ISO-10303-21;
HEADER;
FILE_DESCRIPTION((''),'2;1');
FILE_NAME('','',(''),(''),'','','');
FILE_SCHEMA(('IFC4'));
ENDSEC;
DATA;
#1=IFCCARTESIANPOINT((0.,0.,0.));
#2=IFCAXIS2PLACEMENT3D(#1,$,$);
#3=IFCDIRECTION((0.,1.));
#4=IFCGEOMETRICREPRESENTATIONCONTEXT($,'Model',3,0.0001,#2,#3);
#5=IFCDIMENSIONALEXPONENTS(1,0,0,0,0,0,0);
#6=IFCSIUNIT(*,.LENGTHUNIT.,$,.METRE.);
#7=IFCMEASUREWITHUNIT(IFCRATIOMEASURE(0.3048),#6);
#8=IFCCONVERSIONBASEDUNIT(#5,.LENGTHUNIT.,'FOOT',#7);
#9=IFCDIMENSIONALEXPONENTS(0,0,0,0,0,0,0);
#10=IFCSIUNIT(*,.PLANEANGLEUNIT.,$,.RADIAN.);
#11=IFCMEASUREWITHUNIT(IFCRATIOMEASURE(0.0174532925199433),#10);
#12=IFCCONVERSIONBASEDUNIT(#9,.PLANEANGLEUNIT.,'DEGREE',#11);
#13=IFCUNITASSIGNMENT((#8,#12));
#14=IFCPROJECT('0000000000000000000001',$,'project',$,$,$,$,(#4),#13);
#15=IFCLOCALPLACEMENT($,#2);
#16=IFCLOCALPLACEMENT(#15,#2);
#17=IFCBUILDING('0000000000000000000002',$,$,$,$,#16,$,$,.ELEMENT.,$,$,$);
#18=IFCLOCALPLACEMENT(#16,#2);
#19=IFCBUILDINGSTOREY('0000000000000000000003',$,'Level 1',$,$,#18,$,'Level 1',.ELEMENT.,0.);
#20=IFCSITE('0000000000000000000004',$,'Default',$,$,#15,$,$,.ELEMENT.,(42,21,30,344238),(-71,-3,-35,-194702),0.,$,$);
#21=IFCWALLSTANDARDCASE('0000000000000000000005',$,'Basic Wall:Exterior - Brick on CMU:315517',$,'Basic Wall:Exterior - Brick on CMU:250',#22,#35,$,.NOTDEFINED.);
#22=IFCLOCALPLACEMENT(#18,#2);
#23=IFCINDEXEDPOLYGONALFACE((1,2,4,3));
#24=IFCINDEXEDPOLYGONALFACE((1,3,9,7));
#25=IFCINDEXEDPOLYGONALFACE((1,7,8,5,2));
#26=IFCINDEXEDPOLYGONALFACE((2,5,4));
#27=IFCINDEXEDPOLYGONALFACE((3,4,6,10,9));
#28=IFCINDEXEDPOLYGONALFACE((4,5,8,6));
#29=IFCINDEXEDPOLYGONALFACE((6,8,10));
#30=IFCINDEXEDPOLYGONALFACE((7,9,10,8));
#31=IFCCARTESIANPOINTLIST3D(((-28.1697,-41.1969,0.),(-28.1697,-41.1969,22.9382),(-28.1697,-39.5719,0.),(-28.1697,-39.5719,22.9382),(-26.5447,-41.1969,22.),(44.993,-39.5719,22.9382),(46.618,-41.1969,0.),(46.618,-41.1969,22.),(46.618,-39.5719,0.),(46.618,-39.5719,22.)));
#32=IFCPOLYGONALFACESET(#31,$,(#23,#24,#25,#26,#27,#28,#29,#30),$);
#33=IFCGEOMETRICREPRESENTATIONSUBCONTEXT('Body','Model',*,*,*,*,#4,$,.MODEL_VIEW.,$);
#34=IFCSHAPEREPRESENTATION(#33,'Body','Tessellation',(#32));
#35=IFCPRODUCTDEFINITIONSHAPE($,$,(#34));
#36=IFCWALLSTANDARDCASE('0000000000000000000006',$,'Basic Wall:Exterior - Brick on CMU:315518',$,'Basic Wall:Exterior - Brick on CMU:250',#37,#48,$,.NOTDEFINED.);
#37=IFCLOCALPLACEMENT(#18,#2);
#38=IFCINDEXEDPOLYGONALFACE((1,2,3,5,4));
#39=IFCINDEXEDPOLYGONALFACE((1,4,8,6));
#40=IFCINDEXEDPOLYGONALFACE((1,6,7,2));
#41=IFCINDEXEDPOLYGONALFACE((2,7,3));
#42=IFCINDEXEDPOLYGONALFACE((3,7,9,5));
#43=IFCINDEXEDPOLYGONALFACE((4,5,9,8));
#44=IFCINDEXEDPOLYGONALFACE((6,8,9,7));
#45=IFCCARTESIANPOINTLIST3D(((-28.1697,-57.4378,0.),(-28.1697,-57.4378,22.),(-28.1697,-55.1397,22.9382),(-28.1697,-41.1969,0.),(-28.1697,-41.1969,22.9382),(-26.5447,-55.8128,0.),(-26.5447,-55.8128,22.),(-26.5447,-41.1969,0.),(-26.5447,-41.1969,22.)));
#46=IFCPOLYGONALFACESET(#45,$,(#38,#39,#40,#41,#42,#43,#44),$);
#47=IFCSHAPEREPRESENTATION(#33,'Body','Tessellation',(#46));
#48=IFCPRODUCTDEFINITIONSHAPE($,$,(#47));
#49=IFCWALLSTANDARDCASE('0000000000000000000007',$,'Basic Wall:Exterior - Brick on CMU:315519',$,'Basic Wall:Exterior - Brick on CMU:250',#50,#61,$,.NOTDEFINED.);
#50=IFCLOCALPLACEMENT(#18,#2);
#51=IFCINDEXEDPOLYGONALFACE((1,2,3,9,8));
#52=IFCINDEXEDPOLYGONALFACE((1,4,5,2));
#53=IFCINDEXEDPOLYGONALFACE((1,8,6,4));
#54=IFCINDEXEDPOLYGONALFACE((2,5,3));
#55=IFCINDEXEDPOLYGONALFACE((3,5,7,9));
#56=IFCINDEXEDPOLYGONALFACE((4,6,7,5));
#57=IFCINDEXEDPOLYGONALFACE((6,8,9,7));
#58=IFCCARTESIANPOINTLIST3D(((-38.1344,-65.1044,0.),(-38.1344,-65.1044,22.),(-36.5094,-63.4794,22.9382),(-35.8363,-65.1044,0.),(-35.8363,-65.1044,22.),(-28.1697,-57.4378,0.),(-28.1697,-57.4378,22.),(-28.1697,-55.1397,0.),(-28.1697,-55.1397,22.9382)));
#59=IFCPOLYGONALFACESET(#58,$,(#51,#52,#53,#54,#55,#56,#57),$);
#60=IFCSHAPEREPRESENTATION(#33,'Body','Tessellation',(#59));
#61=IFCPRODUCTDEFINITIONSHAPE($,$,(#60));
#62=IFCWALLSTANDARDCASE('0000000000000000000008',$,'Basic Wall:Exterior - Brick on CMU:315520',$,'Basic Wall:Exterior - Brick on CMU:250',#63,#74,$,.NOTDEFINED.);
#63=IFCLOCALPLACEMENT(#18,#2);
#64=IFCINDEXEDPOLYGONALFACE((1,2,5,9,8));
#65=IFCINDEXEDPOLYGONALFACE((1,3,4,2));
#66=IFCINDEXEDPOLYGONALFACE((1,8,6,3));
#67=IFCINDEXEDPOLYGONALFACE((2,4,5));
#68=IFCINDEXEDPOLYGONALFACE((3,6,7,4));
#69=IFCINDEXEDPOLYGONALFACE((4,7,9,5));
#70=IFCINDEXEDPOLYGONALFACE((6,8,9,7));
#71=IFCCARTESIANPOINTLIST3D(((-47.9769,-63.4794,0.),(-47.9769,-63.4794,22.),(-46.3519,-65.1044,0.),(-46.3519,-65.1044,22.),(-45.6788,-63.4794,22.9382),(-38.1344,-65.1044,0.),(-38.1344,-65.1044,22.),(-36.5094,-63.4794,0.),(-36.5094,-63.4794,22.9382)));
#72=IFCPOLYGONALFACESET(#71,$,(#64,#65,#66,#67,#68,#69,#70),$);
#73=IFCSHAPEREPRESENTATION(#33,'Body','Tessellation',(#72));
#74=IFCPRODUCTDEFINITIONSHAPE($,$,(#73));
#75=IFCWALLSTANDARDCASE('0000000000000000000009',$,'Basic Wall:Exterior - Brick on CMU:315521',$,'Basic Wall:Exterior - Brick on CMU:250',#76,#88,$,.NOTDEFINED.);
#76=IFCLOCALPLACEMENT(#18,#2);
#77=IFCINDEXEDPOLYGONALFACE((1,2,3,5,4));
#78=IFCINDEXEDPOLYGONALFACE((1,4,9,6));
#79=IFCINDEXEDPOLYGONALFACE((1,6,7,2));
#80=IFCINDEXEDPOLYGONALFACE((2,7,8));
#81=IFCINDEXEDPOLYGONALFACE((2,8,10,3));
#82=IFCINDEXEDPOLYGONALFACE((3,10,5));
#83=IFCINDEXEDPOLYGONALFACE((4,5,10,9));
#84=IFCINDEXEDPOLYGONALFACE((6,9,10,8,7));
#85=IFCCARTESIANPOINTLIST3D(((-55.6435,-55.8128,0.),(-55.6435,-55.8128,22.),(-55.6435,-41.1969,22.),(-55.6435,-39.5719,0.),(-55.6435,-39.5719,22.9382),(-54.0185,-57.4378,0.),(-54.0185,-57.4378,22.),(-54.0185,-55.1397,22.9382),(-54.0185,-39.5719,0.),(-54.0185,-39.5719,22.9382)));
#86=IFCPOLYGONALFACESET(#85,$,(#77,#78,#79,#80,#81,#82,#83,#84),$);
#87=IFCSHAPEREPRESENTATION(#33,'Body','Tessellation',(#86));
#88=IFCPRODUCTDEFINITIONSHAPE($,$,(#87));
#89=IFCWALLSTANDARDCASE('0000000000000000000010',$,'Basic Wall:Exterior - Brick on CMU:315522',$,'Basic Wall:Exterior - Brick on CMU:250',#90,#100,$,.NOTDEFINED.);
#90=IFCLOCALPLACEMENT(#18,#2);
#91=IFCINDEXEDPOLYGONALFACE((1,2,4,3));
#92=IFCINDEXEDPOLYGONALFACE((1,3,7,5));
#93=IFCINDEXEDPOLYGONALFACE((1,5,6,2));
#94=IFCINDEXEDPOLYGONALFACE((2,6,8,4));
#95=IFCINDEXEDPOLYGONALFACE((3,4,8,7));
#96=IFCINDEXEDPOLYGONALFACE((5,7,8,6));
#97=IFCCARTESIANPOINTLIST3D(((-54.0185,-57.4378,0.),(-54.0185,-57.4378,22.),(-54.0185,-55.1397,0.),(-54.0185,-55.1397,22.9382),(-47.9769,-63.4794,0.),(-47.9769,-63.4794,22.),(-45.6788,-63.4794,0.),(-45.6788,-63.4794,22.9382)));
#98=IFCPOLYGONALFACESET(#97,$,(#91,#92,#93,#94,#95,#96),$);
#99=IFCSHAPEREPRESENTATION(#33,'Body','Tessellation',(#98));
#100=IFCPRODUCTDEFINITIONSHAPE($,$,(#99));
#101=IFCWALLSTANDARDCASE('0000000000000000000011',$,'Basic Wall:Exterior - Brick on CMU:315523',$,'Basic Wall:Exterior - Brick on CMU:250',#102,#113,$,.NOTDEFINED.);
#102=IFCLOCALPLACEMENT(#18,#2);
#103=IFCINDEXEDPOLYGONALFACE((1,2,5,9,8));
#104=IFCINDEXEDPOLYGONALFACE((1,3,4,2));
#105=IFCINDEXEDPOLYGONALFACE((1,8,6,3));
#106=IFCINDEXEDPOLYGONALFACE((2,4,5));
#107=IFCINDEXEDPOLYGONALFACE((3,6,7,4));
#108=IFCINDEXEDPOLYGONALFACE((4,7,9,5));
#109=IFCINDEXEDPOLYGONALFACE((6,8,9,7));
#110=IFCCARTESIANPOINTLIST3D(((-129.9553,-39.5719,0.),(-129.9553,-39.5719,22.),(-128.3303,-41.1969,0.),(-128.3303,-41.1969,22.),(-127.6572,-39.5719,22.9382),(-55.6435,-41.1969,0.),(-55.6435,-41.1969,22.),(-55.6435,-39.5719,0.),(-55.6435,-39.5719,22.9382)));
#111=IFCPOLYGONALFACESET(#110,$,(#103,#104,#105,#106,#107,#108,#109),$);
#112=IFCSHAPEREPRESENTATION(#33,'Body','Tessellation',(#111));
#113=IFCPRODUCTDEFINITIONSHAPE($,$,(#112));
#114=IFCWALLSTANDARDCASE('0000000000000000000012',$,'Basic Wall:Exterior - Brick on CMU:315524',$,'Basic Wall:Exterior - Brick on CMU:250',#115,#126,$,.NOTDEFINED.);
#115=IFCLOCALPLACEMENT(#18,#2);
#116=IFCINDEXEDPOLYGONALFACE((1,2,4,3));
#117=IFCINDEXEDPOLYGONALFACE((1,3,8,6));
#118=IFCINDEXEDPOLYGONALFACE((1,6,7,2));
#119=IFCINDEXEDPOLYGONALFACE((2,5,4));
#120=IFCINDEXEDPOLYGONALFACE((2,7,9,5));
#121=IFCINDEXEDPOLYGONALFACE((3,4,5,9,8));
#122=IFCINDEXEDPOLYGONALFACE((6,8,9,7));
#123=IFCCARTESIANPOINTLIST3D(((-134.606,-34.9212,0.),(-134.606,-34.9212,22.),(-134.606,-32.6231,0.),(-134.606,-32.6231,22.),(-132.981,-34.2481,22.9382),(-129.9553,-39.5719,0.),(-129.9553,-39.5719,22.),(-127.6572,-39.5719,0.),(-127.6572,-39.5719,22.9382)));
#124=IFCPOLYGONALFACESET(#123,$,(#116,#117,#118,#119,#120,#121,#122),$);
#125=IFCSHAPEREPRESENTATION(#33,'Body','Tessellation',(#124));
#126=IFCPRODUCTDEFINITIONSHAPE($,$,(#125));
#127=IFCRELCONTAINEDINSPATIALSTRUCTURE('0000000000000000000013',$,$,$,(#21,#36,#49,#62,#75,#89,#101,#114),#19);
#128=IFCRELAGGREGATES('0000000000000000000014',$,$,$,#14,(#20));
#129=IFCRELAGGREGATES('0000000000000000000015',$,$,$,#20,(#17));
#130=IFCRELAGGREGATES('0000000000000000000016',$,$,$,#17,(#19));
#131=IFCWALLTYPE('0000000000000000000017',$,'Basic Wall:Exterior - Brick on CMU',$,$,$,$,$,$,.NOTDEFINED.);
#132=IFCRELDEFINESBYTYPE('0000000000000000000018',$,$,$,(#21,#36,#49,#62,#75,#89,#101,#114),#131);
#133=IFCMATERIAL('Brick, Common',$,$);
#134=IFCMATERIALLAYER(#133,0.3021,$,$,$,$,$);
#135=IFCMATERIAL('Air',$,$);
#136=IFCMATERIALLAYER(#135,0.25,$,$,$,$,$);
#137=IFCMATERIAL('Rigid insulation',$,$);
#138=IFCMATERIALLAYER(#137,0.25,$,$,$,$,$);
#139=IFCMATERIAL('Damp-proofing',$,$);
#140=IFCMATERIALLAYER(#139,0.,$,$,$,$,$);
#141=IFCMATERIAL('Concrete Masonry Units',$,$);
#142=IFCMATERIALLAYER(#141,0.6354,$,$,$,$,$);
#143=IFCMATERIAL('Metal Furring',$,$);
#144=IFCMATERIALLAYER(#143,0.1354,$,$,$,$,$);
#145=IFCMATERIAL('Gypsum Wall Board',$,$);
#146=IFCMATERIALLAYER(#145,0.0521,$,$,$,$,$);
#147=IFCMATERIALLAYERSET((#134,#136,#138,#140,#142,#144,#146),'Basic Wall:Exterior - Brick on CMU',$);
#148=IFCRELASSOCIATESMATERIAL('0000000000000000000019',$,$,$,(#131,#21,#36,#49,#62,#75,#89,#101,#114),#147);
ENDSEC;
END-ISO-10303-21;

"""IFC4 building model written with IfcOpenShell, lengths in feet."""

from ifc_helpers import new_model, entity, si_unit, converted_unit, direction, frame, frame_2d, origin, place, context, subcontext, project, spatial, polyline, rectangle, outline, extrude, clip, bounded_halfspace, material, layer, layer_set, layer_usage, type_object, element, save


model = new_model("IFC4")

# Units and contexts
model_context = context("Model", 3, precision=0.0001, world=origin(), true_north=direction((0.0, 1.0)))
body_context = subcontext(model_context, "Body", "Model", "MODEL_VIEW")
ifc_project = project(units=[converted_unit("LENGTHUNIT", "FOOT", entity("IfcRatioMeasure", 0.3048), si_unit("LENGTHUNIT", "METRE"), dimensions=[1, 0, 0, 0, 0, 0, 0]), converted_unit("PLANEANGLEUNIT", "DEGREE", entity("IfcRatioMeasure", 0.0174532925199433), si_unit("PLANEANGLEUNIT", "RADIAN"), dimensions=[0, 0, 0, 0, 0, 0, 0])], contexts=[model_context])

# Site, building, storey
site_placement = place(None, origin())
site = spatial("IfcSite", under=ifc_project, at=site_placement, Name="Default", CompositionType="ELEMENT", RefLatitude=(42, 21, 30, 344238), RefLongitude=(-71, -3, -35, -194702), RefElevation=0.0)
building_placement = place(site_placement, origin())
building = spatial("IfcBuilding", under=site, at=building_placement, CompositionType="ELEMENT")
storey_placement = place(building_placement, origin())
storey = spatial("IfcBuildingStorey", under=building, at=storey_placement, Name="Level 1", LongName="Level 1", CompositionType="ELEMENT", Elevation=0.0)

# Walls
ifc_material_1 = material(Name="Brick, Common")
ifc_layer_1 = layer(ifc_material_1, 0.3021)
ifc_material_2 = material(Name="Air")
ifc_layer_2 = layer(ifc_material_2, 0.25)
ifc_material_3 = material(Name="Rigid insulation")
ifc_layer_3 = layer(ifc_material_3, 0.25)
ifc_material_4 = material(Name="Damp-proofing")
ifc_layer_4 = layer(ifc_material_4, 0.0)
ifc_material_5 = material(Name="Concrete Masonry Units")
ifc_layer_5 = layer(ifc_material_5, 0.6354)
ifc_material_6 = material(Name="Metal Furring")
ifc_layer_6 = layer(ifc_material_6, 0.1354)
ifc_material_7 = material(Name="Gypsum Wall Board")
ifc_layer_7 = layer(ifc_material_7, 0.0521)
ifc_layer_set = layer_set([ifc_layer_1, ifc_layer_2, ifc_layer_3, ifc_layer_4, ifc_layer_5, ifc_layer_6, ifc_layer_7], Name="Basic Wall:Exterior - Brick on CMU")
ifc_layer_usage_1 = layer_usage(ifc_layer_set, "AXIS2", "NEGATIVE", 0.8125)
wall_type = type_object("IfcWallType", Name="Basic Wall:Exterior - Brick on CMU", PredefinedType="NOTDEFINED", material=ifc_layer_set)
wall_1_placement = place(storey_placement, frame((46.618, -40.3844, 0.0), z_axis=(0.0, 0.0, 1.0), x_axis=(-1.0, 0.0, 0.0)))
element("IfcWallStandardCase", 1, at=wall_1_placement, inside=storey, type_object=wall_type, material=ifc_layer_usage_1, Name="Basic Wall:Exterior - Brick on CMU:315517", ObjectType="Basic Wall:Exterior - Brick on CMU:250", PredefinedType="NOTDEFINED", context=body_context, shape_type="Clipping", body=[
    clip(clip(clip(extrude(rectangle(XDim=74.7877, YDim=1.625, at=frame_2d((37.3939, 0.0), x_axis=(-1.0, 0.0))), origin(), (0.0, 0.0, 1.0), 22.9382), bounded_halfspace(frame((74.7877, -0.8125, 22.9382), z_axis=(-0.5, 0.0, 0.866025), x_axis=(0.0, -1.0, 0.0)), False, frame((74.7877, -0.8125, 22.9382)), polyline([(0.0, 0.0), (0.0, 1.625), (-1.625, 1.625), (0.0, 0.0)]))), bounded_halfspace(frame((0.0, -0.8125, 22.0), z_axis=(-0.5, 0.0, 0.866025), x_axis=(0.0, -1.0, 0.0)), False, frame((0.0, -0.8125, 22.0)), polyline([(0.0, 0.0), (1.625, 0.0), (0.0, 1.625), (0.0, 0.0)]))), bounded_halfspace(frame((1.625, -0.8125, 22.9382), z_axis=(0.0, 0.5, 0.866025), x_axis=(-1.0, 0.0, 0.0)), False, frame((1.625, -0.8125, 22.9382)), polyline([(0.0, 0.0), (73.1627, 0.0), (71.5377, 1.625), (-1.625, 1.625), (0.0, 0.0)]))),
])
ifc_layer_usage_2 = layer_usage(ifc_layer_set, "AXIS2", "NEGATIVE", 0.8125)
wall_2_placement = place(storey_placement, frame((-27.3572, -41.1969, 0.0), z_axis=(0.0, 0.0, 1.0), x_axis=(0.0, -1.0, 0.0)))
element("IfcWallStandardCase", 2, at=wall_2_placement, inside=storey, type_object=wall_type, material=ifc_layer_usage_2, Name="Basic Wall:Exterior - Brick on CMU:315518", ObjectType="Basic Wall:Exterior - Brick on CMU:250", PredefinedType="NOTDEFINED", context=body_context, shape_type="Clipping", body=[
    clip(clip(extrude(outline(polyline([(16.2409, -0.8125), (14.6159, 0.8125), (0.0, 0.8125), (0.0, -0.8125), (13.9428, -0.8125), (16.2409, -0.8125)])), origin(), (0.0, 0.0, 1.0), 22.9382), bounded_halfspace(frame((13.9428, -0.8125, 22.9382), z_axis=(0.353553, 0.353553, 0.866025), x_axis=(-0.707107, 0.707107, 0.0)), False, frame((13.9428, -0.8125, 22.9382)), polyline([(0.0, 0.0), (2.2981, 0.0), (0.6731, 1.625), (0.0, 0.0)]))), bounded_halfspace(frame((0.0, -0.8125, 22.9382), z_axis=(0.0, 0.5, 0.866025), x_axis=(-1.0, 0.0, 0.0)), False, frame((0.0, -0.8125, 22.9382)), polyline([(0.0, 0.0), (13.9428, 0.0), (14.6159, 1.625), (0.0, 1.625), (0.0, 0.0)]))),
])
ifc_layer_usage_3 = layer_usage(ifc_layer_set, "AXIS2", "NEGATIVE", 0.8125)
wall_3_placement = place(storey_placement, frame((-27.5952, -55.7142, 0.0), z_axis=(0.0, 0.0, 1.0), x_axis=(-0.707107, -0.707107, 0.0)))
element("IfcWallStandardCase", 3, at=wall_3_placement, inside=storey, type_object=wall_type, material=ifc_layer_usage_3, Name="Basic Wall:Exterior - Brick on CMU:315519", ObjectType="Basic Wall:Exterior - Brick on CMU:250", PredefinedType="NOTDEFINED", context=body_context, shape_type="Clipping", body=[
    clip(clip(extrude(outline(polyline([(14.0922, -0.8125), (12.4672, 0.8125), (1.625, 0.8125), (0.0, -0.8125), (11.7941, -0.8125), (14.0922, -0.8125)])), origin(), (0.0, 0.0, 1.0), 22.9382), bounded_halfspace(frame((0.0, -0.8125, 22.9382), z_axis=(0.0, 0.5, 0.866025), x_axis=(-1.0, 0.0, 0.0)), False, frame((0.0, -0.8125, 22.9382)), polyline([(0.0, 0.0), (11.7941, 0.0), (12.4672, 1.625), (1.625, 1.625), (0.0, 0.0)]))), bounded_halfspace(frame((11.7941, -0.8125, 22.9382), z_axis=(0.353553, 0.353553, 0.866025), x_axis=(-0.707107, 0.707107, 0.0)), False, frame((11.7941, -0.8125, 22.9382)), polyline([(0.0, 0.0), (2.2981, 0.0), (0.6731, 1.625), (0.0, 0.0)]))),
])
ifc_layer_usage_4 = layer_usage(ifc_layer_set, "AXIS2", "NEGATIVE", 0.8125)
wall_4_placement = place(storey_placement, frame((-36.5094, -64.2919, 0.0), z_axis=(0.0, 0.0, 1.0), x_axis=(-1.0, 0.0, 0.0)))
element("IfcWallStandardCase", 4, at=wall_4_placement, inside=storey, type_object=wall_type, material=ifc_layer_usage_4, Name="Basic Wall:Exterior - Brick on CMU:315520", ObjectType="Basic Wall:Exterior - Brick on CMU:250", PredefinedType="NOTDEFINED", context=body_context, shape_type="Clipping", body=[
    clip(clip(extrude(outline(polyline([(11.4675, -0.8125), (9.8425, 0.8125), (1.625, 0.8125), (0.0, -0.8125), (9.1694, -0.8125), (11.4675, -0.8125)])), origin(), (0.0, 0.0, 1.0), 22.9382), bounded_halfspace(frame((9.1694, -0.8125, 22.9382), z_axis=(0.353553, 0.353553, 0.866025), x_axis=(-0.707107, 0.707107, 0.0)), False, frame((9.1694, -0.8125, 22.9382)), polyline([(0.0, 0.0), (2.2981, 0.0), (0.6731, 1.625), (0.0, 0.0)]))), bounded_halfspace(frame((0.0, -0.8125, 22.9382), z_axis=(0.0, 0.5, 0.866025), x_axis=(-1.0, 0.0, 0.0)), False, frame((0.0, -0.8125, 22.9382)), polyline([(0.0, 0.0), (9.1694, 0.0), (9.8425, 1.625), (1.625, 1.625), (0.0, 0.0)]))),
])
ifc_layer_usage_5 = layer_usage(ifc_layer_set, "AXIS2", "POSITIVE", -0.8125)
wall_5_placement = place(storey_placement, frame((-54.831, -39.5719, 0.0), z_axis=(0.0, 0.0, 1.0), x_axis=(0.0, -1.0, 0.0)))
element("IfcWallStandardCase", 5, at=wall_5_placement, inside=storey, type_object=wall_type, material=ifc_layer_usage_5, Name="Basic Wall:Exterior - Brick on CMU:315521", ObjectType="Basic Wall:Exterior - Brick on CMU:250", PredefinedType="NOTDEFINED", context=body_context, shape_type="Clipping", body=[
    clip(clip(clip(extrude(outline(polyline([(16.2409, -0.8125), (17.8659, 0.8125), (15.5678, 0.8125), (0.0, 0.8125), (0.0, -0.8125), (1.625, -0.8125), (16.2409, -0.8125)])), origin(), (0.0, 0.0, 1.0), 22.9382), bounded_halfspace(frame((1.625, -0.8125, 22.0), z_axis=(0.0, -0.5, 0.866025), x_axis=(1.0, 0.0, 0.0)), False, frame((1.625, -0.8125, 22.0)), polyline([(0.0, 0.0), (14.6159, 0.0), (13.9428, 1.625), (-1.625, 1.625), (0.0, 0.0)]))), bounded_halfspace(frame((16.2409, -0.8125, 22.0), z_axis=(0.353553, -0.353553, 0.866025), x_axis=(0.707107, 0.707107, 0.0)), False, frame((16.2409, -0.8125, 22.0)), polyline([(0.0, 0.0), (1.625, 1.625), (-0.6731, 1.625), (0.0, 0.0)]))), bounded_halfspace(frame((0.0, -0.8125, 22.9382), z_axis=(0.5, 0.0, 0.866025), x_axis=(0.0, 1.0, 0.0)), False, frame((0.0, -0.8125, 22.9382)), polyline([(0.0, 0.0), (1.625, 0.0), (0.0, 1.625), (0.0, 0.0)]))),
])
ifc_layer_usage_6 = layer_usage(ifc_layer_set, "AXIS2", "POSITIVE", -0.8125)
wall_6_placement = place(storey_placement, frame((-54.593, -55.7142, 0.0), z_axis=(0.0, 0.0, 1.0), x_axis=(0.707107, -0.707107, 0.0)))
element("IfcWallStandardCase", 6, at=wall_6_placement, inside=storey, type_object=wall_type, material=ifc_layer_usage_6, Name="Basic Wall:Exterior - Brick on CMU:315522", ObjectType="Basic Wall:Exterior - Brick on CMU:250", PredefinedType="NOTDEFINED", context=body_context, shape_type="Clipping", body=[
    clip(extrude(outline(polyline([(10.1691, -0.8125), (11.7941, 0.8125), (0.0, 0.8125), (1.625, -0.8125), (10.1691, -0.8125)])), origin(), (0.0, 0.0, 1.0), 22.9382), bounded_halfspace(frame((1.625, -0.8125, 22.0), z_axis=(0.0, -0.5, 0.866025), x_axis=(1.0, 0.0, 0.0)), False, frame((1.625, -0.8125, 22.0)), polyline([(0.0, 0.0), (8.5441, 0.0), (10.1691, 1.625), (-1.625, 1.625), (0.0, 0.0)]))),
])
ifc_layer_usage_7 = layer_usage(ifc_layer_set, "AXIS2", "POSITIVE", -0.8125)
wall_7_placement = place(storey_placement, frame((-129.9553, -40.3844, 0.0)))
element("IfcWallStandardCase", 7, at=wall_7_placement, inside=storey, type_object=wall_type, material=ifc_layer_usage_7, Name="Basic Wall:Exterior - Brick on CMU:315523", ObjectType="Basic Wall:Exterior - Brick on CMU:250", PredefinedType="NOTDEFINED", context=body_context, shape_type="Clipping", body=[
    clip(clip(extrude(outline(polyline([(74.3118, -0.8125), (74.3118, 0.8125), (2.2981, 0.8125), (0.0, 0.8125), (1.625, -0.8125), (74.3118, -0.8125)])), origin(), (0.0, 0.0, 1.0), 22.9382), bounded_halfspace(frame((2.2981, 0.8125, 22.9382), z_axis=(-0.353553, -0.353553, 0.866025), x_axis=(0.707107, -0.707107, 0.0)), False, frame((2.2981, 0.8125, 22.9382)), polyline([(0.0, 0.0), (-2.2981, 0.0), (-0.6731, -1.625), (0.0, 0.0)]))), bounded_halfspace(frame((1.625, -0.8125, 22.0), z_axis=(0.0, -0.5, 0.866025), x_axis=(1.0, 0.0, 0.0)), False, frame((1.625, -0.8125, 22.0)), polyline([(0.0, 0.0), (72.6868, 0.0), (72.6868, 1.625), (0.6731, 1.625), (0.0, 0.0)]))),
])
ifc_layer_usage_8 = layer_usage(ifc_layer_set, "AXIS2", "NEGATIVE", 0.8125)
wall_8_placement = place(storey_placement, frame((-128.2317, -40.1464, 0.0), z_axis=(0.0, 0.0, 1.0), x_axis=(-0.707107, 0.707107, 0.0)))
element("IfcWallStandardCase", 8, at=wall_8_placement, inside=storey, type_object=wall_type, material=ifc_layer_usage_8, Name="Basic Wall:Exterior - Brick on CMU:315524", ObjectType="Basic Wall:Exterior - Brick on CMU:250", PredefinedType="NOTDEFINED", context=body_context, shape_type="Clipping", body=[
    clip(clip(extrude(outline(polyline([(9.8271, -0.8125), (8.2021, 0.8125), (1.625, 0.8125), (0.0, -0.8125), (7.529, -0.8125), (9.8271, -0.8125)])), origin(), (0.0, 0.0, 1.0), 22.9382), bounded_halfspace(frame((0.0, -0.8125, 22.9382), z_axis=(0.0, 0.5, 0.866025), x_axis=(-1.0, 0.0, 0.0)), False, frame((0.0, -0.8125, 22.9382)), polyline([(0.0, 0.0), (7.529, 0.0), (8.2021, 1.625), (1.625, 1.625), (0.0, 0.0)]))), bounded_halfspace(frame((7.529, -0.8125, 22.9382), z_axis=(0.353553, 0.353553, 0.866025), x_axis=(-0.707107, 0.707107, 0.0)), False, frame((7.529, -0.8125, 22.9382)), polyline([(0.0, 0.0), (2.2981, 0.0), (0.6731, 1.625), (0.0, 0.0)]))),
])

save(model, "model.ifc")
